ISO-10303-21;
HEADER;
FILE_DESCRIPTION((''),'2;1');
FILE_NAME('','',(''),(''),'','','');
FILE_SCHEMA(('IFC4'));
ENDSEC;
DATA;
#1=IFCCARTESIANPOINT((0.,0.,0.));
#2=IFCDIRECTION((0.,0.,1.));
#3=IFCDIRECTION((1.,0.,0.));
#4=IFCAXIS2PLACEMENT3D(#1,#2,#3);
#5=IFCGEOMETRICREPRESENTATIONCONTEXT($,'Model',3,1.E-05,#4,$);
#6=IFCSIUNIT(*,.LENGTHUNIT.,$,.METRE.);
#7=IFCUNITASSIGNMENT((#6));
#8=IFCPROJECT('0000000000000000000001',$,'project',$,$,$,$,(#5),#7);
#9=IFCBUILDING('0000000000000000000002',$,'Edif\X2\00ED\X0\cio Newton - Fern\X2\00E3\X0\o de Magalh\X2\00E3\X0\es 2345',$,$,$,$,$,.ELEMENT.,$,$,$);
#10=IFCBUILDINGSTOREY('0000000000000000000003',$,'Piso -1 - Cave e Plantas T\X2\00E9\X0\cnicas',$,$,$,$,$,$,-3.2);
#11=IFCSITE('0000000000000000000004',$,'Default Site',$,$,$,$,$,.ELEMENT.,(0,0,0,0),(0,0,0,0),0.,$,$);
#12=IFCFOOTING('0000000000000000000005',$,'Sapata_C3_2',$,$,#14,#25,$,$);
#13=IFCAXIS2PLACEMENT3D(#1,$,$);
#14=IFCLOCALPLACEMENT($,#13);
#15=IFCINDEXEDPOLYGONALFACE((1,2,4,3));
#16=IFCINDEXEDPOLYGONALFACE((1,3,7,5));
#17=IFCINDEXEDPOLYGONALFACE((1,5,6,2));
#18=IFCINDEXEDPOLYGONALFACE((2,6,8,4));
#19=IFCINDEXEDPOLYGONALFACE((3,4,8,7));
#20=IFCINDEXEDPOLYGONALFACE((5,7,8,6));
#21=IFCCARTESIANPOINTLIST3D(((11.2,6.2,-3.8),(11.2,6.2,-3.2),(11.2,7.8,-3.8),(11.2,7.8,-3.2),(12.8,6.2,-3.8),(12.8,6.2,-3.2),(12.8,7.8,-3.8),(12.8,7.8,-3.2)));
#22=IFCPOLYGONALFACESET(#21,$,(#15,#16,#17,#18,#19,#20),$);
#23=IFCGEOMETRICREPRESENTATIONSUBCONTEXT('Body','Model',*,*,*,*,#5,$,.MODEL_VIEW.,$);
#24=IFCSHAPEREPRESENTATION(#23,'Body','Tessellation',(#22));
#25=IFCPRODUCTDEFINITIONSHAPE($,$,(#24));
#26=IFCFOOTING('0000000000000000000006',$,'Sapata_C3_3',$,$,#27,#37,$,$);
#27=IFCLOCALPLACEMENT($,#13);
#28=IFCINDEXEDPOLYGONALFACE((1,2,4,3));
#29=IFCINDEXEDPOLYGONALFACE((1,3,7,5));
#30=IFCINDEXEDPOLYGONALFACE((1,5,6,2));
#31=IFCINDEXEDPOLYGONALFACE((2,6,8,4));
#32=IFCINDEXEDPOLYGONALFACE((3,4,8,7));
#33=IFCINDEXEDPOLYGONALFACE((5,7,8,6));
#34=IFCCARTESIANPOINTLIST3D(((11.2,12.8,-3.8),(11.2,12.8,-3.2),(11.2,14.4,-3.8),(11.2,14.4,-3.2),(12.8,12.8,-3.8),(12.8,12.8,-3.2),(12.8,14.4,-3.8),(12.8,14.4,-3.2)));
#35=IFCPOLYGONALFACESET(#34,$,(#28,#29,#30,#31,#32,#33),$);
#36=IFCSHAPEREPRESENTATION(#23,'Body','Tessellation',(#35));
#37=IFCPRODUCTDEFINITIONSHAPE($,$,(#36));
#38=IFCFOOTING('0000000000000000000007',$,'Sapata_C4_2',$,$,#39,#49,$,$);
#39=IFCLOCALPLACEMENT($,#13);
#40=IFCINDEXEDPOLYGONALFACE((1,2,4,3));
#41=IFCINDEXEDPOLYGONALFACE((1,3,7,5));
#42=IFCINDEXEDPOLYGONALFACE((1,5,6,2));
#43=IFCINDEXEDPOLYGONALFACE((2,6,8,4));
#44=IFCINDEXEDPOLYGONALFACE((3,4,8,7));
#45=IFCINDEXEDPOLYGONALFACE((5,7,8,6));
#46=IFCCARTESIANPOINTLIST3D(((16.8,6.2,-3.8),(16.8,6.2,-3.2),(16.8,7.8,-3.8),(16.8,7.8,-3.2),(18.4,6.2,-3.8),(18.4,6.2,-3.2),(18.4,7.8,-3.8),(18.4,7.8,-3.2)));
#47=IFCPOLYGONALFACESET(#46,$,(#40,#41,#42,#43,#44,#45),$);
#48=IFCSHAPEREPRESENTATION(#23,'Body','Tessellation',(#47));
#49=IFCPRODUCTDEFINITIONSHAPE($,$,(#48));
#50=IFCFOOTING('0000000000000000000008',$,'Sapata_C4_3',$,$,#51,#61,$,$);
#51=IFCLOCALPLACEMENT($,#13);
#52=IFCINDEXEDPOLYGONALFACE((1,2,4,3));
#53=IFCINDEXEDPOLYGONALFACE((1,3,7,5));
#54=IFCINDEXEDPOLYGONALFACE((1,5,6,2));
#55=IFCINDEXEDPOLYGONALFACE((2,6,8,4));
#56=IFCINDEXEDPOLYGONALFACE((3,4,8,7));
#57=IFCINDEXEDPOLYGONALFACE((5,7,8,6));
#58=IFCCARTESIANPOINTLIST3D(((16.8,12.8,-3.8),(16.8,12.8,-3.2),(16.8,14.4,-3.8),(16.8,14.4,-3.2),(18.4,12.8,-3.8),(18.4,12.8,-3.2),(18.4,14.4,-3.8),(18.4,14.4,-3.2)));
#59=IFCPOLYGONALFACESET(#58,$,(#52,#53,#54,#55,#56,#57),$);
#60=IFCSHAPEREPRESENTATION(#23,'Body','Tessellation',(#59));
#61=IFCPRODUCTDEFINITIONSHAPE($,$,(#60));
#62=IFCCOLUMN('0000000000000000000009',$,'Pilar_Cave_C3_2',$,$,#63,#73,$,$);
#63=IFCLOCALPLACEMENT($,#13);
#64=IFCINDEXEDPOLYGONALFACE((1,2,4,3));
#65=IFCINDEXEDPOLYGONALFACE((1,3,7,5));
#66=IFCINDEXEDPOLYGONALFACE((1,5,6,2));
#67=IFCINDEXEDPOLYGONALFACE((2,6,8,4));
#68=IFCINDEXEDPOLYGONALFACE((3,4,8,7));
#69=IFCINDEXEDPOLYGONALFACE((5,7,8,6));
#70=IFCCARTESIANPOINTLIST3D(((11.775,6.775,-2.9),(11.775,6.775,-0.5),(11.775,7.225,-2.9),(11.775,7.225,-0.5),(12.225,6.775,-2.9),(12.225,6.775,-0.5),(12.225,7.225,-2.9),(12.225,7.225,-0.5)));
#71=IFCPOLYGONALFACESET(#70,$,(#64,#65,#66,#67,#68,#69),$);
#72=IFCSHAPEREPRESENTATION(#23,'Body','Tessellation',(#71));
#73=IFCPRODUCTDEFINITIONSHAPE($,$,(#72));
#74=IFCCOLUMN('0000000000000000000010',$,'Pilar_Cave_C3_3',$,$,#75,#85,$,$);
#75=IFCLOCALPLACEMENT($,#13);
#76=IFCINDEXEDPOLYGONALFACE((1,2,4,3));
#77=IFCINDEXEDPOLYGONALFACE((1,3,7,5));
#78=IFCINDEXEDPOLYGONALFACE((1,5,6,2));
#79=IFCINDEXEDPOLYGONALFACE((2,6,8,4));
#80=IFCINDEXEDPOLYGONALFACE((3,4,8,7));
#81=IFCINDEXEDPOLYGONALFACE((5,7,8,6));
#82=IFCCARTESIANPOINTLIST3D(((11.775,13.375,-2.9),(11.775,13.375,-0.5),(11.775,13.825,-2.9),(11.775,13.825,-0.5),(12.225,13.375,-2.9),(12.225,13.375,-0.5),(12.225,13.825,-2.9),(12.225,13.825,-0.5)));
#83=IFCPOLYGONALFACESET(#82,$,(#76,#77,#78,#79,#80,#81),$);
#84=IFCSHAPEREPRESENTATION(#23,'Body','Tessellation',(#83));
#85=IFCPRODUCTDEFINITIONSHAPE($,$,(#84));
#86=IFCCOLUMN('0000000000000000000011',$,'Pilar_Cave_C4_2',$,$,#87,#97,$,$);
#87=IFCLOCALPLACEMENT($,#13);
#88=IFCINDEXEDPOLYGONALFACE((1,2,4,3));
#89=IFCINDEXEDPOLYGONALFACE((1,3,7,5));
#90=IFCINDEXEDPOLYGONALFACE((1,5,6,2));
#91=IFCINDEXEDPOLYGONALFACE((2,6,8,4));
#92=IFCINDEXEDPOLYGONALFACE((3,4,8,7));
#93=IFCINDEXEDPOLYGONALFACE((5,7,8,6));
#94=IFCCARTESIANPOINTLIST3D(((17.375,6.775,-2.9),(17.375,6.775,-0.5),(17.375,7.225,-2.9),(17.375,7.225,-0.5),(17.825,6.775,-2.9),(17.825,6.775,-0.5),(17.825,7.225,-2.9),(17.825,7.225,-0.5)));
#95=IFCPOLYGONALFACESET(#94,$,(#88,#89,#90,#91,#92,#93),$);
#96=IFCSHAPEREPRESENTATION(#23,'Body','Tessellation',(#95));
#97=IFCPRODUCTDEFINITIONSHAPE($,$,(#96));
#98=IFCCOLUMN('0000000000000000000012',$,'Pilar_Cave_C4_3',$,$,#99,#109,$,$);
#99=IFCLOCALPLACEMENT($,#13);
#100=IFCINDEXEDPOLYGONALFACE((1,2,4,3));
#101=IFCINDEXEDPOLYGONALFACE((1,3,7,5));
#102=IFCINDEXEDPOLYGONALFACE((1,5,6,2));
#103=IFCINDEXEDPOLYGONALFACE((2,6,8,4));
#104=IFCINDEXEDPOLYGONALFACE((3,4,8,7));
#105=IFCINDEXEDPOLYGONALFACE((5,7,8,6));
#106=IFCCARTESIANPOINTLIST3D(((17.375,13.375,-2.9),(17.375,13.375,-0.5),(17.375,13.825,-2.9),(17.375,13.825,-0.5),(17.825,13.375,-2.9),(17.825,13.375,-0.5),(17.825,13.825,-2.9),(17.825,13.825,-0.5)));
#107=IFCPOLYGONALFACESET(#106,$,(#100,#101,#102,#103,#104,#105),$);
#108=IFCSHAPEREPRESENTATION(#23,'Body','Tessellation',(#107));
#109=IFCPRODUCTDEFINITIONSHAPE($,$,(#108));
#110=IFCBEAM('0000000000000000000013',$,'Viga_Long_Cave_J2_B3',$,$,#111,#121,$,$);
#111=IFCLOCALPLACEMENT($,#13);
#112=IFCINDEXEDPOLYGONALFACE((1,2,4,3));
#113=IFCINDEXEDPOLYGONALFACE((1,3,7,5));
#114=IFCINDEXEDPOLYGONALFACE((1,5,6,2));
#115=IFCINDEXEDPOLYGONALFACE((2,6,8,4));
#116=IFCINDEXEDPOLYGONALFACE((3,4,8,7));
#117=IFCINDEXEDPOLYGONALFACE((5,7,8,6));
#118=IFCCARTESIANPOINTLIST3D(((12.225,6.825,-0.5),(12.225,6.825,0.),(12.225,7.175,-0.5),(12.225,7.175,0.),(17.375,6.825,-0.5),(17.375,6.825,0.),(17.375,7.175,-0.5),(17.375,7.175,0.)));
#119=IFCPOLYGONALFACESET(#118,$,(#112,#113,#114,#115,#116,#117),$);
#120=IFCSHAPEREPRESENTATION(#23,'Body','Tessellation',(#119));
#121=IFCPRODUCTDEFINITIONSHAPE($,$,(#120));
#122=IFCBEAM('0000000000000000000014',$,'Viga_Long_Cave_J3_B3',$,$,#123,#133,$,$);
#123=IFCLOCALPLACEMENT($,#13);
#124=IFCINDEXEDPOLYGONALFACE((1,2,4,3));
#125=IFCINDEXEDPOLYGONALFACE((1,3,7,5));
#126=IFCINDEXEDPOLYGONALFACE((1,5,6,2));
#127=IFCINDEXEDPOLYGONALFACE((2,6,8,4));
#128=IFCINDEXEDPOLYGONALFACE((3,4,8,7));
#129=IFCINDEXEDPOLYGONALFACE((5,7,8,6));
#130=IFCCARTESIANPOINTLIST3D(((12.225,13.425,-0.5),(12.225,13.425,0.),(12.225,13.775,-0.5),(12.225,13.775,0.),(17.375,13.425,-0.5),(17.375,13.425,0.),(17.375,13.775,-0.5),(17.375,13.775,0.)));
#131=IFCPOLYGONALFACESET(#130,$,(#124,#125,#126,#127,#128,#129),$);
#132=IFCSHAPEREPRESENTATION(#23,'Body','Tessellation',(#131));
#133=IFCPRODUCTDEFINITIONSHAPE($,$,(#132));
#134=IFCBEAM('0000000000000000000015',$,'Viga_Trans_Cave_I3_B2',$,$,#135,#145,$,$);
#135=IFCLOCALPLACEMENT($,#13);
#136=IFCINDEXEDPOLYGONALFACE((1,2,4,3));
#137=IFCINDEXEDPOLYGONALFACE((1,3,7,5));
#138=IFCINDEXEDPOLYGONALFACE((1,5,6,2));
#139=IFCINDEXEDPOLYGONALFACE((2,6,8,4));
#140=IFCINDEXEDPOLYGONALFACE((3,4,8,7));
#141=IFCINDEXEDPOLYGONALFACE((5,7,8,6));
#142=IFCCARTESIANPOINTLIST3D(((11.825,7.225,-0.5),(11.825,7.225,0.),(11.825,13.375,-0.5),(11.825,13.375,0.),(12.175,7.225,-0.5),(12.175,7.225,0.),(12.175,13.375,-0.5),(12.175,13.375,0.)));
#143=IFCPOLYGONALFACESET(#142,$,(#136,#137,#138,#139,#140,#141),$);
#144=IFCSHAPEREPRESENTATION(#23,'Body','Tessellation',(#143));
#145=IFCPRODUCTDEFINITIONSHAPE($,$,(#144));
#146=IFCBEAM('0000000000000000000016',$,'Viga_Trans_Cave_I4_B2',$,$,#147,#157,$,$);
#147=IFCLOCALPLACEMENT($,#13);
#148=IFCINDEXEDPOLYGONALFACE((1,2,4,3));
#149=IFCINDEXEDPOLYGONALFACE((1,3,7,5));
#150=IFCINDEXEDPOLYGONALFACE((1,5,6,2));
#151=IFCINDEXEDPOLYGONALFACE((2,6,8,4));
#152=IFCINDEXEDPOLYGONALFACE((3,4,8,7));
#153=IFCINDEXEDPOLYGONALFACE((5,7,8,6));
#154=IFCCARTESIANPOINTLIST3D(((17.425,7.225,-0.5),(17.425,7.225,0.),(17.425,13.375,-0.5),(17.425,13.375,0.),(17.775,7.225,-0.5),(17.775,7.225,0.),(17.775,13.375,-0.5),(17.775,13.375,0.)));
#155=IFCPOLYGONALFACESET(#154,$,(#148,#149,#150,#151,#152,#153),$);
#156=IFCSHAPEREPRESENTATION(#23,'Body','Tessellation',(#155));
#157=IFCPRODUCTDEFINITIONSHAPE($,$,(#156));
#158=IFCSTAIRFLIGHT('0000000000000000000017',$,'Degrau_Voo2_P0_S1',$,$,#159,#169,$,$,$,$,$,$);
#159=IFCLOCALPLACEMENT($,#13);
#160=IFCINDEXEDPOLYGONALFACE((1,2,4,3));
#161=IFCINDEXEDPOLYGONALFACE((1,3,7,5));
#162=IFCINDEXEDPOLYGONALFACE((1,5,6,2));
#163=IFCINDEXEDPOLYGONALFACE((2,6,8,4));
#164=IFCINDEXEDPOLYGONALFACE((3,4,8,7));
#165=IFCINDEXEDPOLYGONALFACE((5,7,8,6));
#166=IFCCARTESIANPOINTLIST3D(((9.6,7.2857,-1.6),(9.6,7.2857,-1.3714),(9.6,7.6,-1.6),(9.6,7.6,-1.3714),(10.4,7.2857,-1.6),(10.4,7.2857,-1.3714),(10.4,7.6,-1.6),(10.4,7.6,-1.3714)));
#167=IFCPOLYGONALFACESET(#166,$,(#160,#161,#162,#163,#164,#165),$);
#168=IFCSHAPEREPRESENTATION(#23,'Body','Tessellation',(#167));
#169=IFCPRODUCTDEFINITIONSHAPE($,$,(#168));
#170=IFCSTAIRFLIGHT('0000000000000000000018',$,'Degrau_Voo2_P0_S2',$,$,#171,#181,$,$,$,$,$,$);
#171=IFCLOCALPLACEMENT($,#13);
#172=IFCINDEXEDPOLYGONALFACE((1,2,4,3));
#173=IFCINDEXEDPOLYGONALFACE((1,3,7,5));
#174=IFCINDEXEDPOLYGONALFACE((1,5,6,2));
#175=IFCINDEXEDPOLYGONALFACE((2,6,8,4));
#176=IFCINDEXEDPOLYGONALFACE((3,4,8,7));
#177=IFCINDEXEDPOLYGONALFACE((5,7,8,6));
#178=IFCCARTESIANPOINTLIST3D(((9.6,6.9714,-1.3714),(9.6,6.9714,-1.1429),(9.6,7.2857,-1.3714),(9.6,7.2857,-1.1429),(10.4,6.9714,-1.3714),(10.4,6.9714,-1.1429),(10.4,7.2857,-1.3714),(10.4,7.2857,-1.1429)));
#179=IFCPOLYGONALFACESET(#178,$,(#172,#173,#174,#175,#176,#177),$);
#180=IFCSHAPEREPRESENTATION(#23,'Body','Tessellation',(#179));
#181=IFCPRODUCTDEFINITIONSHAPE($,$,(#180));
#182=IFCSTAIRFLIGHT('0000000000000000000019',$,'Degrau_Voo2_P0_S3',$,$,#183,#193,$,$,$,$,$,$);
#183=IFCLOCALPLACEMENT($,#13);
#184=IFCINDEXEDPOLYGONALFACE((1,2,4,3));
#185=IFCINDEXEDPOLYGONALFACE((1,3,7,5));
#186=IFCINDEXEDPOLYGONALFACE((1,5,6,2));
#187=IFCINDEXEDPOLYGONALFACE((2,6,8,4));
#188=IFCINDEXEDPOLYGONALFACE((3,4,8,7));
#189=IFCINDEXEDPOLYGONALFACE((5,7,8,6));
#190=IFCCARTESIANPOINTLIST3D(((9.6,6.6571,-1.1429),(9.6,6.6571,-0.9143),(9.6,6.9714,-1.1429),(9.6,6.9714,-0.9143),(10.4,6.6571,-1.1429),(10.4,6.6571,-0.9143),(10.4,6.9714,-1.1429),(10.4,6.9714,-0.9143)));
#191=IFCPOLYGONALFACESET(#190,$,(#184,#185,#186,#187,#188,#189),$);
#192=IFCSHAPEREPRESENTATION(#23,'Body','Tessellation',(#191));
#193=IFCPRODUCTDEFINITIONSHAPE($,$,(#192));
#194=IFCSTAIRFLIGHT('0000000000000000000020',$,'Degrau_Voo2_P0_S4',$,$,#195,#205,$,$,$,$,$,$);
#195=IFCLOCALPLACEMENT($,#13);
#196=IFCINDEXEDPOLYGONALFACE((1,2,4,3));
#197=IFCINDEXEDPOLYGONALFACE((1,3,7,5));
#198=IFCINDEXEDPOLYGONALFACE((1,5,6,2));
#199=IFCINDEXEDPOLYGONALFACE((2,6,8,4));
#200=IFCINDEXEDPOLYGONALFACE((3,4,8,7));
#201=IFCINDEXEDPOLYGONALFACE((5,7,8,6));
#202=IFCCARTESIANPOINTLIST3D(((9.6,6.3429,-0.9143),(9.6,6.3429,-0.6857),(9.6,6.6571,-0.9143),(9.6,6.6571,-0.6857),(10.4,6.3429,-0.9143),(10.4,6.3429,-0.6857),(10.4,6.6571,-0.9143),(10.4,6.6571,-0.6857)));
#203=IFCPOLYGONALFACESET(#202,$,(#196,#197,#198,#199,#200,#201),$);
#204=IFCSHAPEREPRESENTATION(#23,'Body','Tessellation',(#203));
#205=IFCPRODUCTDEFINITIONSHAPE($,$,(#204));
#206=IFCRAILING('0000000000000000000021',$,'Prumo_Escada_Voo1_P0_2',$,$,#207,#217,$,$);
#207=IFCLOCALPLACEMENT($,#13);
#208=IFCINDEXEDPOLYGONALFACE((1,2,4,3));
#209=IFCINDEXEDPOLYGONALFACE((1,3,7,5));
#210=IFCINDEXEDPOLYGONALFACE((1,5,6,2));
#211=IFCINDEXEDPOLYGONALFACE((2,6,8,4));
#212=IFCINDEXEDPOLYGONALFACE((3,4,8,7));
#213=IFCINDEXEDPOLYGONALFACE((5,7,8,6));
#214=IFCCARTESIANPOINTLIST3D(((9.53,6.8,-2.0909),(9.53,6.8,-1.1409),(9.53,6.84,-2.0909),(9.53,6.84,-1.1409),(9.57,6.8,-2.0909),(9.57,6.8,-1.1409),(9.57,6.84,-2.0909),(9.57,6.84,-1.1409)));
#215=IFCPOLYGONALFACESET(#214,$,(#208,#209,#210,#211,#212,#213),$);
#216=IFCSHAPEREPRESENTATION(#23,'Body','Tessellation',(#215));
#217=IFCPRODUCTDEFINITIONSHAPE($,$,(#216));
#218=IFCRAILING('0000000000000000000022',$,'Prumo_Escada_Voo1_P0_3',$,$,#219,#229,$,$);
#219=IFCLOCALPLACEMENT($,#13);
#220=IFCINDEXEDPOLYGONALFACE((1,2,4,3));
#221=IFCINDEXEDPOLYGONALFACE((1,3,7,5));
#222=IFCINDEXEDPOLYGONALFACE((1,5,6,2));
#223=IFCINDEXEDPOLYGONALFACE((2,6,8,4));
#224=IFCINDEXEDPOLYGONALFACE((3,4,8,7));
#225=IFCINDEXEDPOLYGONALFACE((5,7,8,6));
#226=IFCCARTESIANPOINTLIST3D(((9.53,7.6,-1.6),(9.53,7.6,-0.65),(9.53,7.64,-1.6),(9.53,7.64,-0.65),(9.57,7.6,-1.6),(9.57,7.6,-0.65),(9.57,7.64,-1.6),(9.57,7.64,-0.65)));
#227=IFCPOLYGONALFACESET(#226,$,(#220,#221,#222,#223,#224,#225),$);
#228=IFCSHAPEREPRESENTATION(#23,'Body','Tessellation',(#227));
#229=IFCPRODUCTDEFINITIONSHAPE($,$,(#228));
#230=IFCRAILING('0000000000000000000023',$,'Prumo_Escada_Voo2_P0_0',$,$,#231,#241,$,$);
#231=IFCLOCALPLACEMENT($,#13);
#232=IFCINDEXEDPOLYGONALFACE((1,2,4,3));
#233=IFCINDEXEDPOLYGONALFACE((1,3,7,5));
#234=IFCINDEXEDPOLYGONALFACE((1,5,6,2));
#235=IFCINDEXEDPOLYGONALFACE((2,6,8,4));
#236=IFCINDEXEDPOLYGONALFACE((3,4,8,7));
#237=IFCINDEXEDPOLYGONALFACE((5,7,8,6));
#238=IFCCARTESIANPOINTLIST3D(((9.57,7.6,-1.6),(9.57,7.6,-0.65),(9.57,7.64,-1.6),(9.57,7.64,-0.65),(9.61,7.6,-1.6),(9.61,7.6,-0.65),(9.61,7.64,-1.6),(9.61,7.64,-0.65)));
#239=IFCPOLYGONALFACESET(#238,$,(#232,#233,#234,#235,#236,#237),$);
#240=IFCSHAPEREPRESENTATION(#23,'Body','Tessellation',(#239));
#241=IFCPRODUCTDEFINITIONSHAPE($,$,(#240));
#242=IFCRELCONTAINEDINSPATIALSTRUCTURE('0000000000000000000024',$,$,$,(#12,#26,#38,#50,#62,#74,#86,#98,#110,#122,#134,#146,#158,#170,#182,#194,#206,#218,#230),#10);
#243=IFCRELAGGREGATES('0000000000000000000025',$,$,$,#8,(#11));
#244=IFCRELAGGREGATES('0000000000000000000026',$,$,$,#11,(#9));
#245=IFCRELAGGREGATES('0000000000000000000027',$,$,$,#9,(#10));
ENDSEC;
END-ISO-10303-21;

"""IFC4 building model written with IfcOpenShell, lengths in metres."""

from ifc_helpers import new_model, si_unit, frame, frame_2d, origin_with_axes, place, context, subcontext, project, spatial, rectangle, extrude, element, save


model = new_model("IFC4")

# Units and contexts
model_context = context("Model", 3, precision=1e-05, world=origin_with_axes())
body_context = subcontext(model_context, "Body", "Model", "MODEL_VIEW")
ifc_project = project(units=[si_unit("LENGTHUNIT", "METRE")], contexts=[model_context])

# Site, building, storey
site = spatial("IfcSite", under=ifc_project, Name="Default Site", CompositionType="ELEMENT", RefLatitude=(0, 0, 0, 0), RefLongitude=(0, 0, 0, 0), RefElevation=0.0)
building = spatial("IfcBuilding", under=site, Name="Edifício Newton - Fernão de Magalhães 2345", CompositionType="ELEMENT")
storey = spatial("IfcBuildingStorey", under=building, Name="Piso -1 - Cave e Plantas Técnicas", Elevation=-3.2)

# Footings
for number, where, z_axis, x_axis, name in (
    (1, (11.2, 6.2, -3.8), (0.0, 0.0, 1.0), (1.0, 0.0, 0.0), "Sapata_C3_2"),
    (2, (11.2, 12.8, -3.8), (0.0, 0.0, 1.0), (1.0, 0.0, 0.0), "Sapata_C3_3"),
    (3, (16.8, 6.2, -3.8), (0.0, 0.0, 1.0), (1.0, 0.0, 0.0), "Sapata_C4_2"),
    (4, (16.8, 12.8, -3.8), (0.0, 0.0, 1.0), (1.0, 0.0, 0.0), "Sapata_C4_3"),
):
    element("IfcFooting", number, at=place(None, frame(where, z_axis=z_axis, x_axis=x_axis)), inside=storey, Name=name, context=body_context, shape_type="SweptSolid", body=[
        extrude(rectangle(XDim=1.6, YDim=1.6, at=frame_2d((0.8, 0.8))), origin_with_axes(), (0.0, 0.0, 1.0), 0.6),
    ])

# Columns
for number, where, z_axis, x_axis, name in (
    (5, (11.775, 6.775, -2.9), (0.0, 0.0, 1.0), (1.0, 0.0, 0.0), "Pilar_Cave_C3_2"),
    (6, (11.775, 13.375, -2.9), (0.0, 0.0, 1.0), (1.0, 0.0, 0.0), "Pilar_Cave_C3_3"),
    (7, (17.375, 6.775, -2.9), (0.0, 0.0, 1.0), (1.0, 0.0, 0.0), "Pilar_Cave_C4_2"),
    (8, (17.375, 13.375, -2.9), (0.0, 0.0, 1.0), (1.0, 0.0, 0.0), "Pilar_Cave_C4_3"),
):
    element("IfcColumn", number, at=place(None, frame(where, z_axis=z_axis, x_axis=x_axis)), inside=storey, Name=name, context=body_context, shape_type="SweptSolid", body=[
        extrude(rectangle(XDim=0.45, YDim=0.45, at=frame_2d((0.225, 0.225))), origin_with_axes(), (0.0, 0.0, 1.0), 2.4),
    ])

# Beams
for number, where, z_axis, x_axis, name in (
    (9, (12.225, 6.825, -0.5), (0.0, 0.0, 1.0), (1.0, 0.0, 0.0), "Viga_Long_Cave_J2_B3"),
    (10, (12.225, 13.425, -0.5), (0.0, 0.0, 1.0), (1.0, 0.0, 0.0), "Viga_Long_Cave_J3_B3"),
):
    element("IfcBeam", number, at=place(None, frame(where, z_axis=z_axis, x_axis=x_axis)), inside=storey, Name=name, context=body_context, shape_type="SweptSolid", body=[
        extrude(rectangle(XDim=5.15, YDim=0.35, at=frame_2d((2.575, 0.175))), origin_with_axes(), (0.0, 0.0, 1.0), 0.5),
    ])
for number, where, z_axis, x_axis, name in (
    (11, (11.825, 7.225, -0.5), (0.0, 0.0, 1.0), (1.0, 0.0, 0.0), "Viga_Trans_Cave_I3_B2"),
    (12, (17.425, 7.225, -0.5), (0.0, 0.0, 1.0), (1.0, 0.0, 0.0), "Viga_Trans_Cave_I4_B2"),
):
    element("IfcBeam", number, at=place(None, frame(where, z_axis=z_axis, x_axis=x_axis)), inside=storey, Name=name, context=body_context, shape_type="SweptSolid", body=[
        extrude(rectangle(XDim=0.35, YDim=6.15, at=frame_2d((0.175, 3.075))), origin_with_axes(), (0.0, 0.0, 1.0), 0.5),
    ])

# Stair flights
for number, where, z_axis, x_axis, name in (
    (13, (9.6, 7.2857, -1.6), (0.0, 0.0, 1.0), (1.0, 0.0, 0.0), "Degrau_Voo2_P0_S1"),
    (14, (9.6, 6.9714, -1.3714), (0.0, 0.0, 1.0), (1.0, 0.0, 0.0), "Degrau_Voo2_P0_S2"),
    (15, (9.6, 6.6571, -1.1429), (0.0, 0.0, 1.0), (1.0, 0.0, 0.0), "Degrau_Voo2_P0_S3"),
    (16, (9.6, 6.3429, -0.9143), (0.0, 0.0, 1.0), (1.0, 0.0, 0.0), "Degrau_Voo2_P0_S4"),
):
    element("IfcStairFlight", number, at=place(None, frame(where, z_axis=z_axis, x_axis=x_axis)), inside=storey, Name=name, context=body_context, shape_type="SweptSolid", body=[
        extrude(rectangle(XDim=0.8, YDim=0.3143, at=frame_2d((0.4, 0.1571))), origin_with_axes(), (0.0, 0.0, 1.0), 0.2286),
    ])

# Railings
for number, where, z_axis, x_axis, name in (
    (17, (9.53, 6.8, -2.0909), (0.0, 0.0, 1.0), (1.0, 0.0, 0.0), "Prumo_Escada_Voo1_P0_2"),
    (18, (9.53, 7.6, -1.6), (0.0, 0.0, 1.0), (1.0, 0.0, 0.0), "Prumo_Escada_Voo1_P0_3"),
    (19, (9.57, 7.6, -1.6), (0.0, 0.0, 1.0), (1.0, 0.0, 0.0), "Prumo_Escada_Voo2_P0_0"),
):
    element("IfcRailing", number, at=place(None, frame(where, z_axis=z_axis, x_axis=x_axis)), inside=storey, Name=name, context=body_context, shape_type="SweptSolid", body=[
        extrude(rectangle(XDim=0.04, YDim=0.04, at=frame_2d((0.02, 0.02))), origin_with_axes(), (0.0, 0.0, 1.0), 0.95),
    ])

save(model, "model.ifc")
